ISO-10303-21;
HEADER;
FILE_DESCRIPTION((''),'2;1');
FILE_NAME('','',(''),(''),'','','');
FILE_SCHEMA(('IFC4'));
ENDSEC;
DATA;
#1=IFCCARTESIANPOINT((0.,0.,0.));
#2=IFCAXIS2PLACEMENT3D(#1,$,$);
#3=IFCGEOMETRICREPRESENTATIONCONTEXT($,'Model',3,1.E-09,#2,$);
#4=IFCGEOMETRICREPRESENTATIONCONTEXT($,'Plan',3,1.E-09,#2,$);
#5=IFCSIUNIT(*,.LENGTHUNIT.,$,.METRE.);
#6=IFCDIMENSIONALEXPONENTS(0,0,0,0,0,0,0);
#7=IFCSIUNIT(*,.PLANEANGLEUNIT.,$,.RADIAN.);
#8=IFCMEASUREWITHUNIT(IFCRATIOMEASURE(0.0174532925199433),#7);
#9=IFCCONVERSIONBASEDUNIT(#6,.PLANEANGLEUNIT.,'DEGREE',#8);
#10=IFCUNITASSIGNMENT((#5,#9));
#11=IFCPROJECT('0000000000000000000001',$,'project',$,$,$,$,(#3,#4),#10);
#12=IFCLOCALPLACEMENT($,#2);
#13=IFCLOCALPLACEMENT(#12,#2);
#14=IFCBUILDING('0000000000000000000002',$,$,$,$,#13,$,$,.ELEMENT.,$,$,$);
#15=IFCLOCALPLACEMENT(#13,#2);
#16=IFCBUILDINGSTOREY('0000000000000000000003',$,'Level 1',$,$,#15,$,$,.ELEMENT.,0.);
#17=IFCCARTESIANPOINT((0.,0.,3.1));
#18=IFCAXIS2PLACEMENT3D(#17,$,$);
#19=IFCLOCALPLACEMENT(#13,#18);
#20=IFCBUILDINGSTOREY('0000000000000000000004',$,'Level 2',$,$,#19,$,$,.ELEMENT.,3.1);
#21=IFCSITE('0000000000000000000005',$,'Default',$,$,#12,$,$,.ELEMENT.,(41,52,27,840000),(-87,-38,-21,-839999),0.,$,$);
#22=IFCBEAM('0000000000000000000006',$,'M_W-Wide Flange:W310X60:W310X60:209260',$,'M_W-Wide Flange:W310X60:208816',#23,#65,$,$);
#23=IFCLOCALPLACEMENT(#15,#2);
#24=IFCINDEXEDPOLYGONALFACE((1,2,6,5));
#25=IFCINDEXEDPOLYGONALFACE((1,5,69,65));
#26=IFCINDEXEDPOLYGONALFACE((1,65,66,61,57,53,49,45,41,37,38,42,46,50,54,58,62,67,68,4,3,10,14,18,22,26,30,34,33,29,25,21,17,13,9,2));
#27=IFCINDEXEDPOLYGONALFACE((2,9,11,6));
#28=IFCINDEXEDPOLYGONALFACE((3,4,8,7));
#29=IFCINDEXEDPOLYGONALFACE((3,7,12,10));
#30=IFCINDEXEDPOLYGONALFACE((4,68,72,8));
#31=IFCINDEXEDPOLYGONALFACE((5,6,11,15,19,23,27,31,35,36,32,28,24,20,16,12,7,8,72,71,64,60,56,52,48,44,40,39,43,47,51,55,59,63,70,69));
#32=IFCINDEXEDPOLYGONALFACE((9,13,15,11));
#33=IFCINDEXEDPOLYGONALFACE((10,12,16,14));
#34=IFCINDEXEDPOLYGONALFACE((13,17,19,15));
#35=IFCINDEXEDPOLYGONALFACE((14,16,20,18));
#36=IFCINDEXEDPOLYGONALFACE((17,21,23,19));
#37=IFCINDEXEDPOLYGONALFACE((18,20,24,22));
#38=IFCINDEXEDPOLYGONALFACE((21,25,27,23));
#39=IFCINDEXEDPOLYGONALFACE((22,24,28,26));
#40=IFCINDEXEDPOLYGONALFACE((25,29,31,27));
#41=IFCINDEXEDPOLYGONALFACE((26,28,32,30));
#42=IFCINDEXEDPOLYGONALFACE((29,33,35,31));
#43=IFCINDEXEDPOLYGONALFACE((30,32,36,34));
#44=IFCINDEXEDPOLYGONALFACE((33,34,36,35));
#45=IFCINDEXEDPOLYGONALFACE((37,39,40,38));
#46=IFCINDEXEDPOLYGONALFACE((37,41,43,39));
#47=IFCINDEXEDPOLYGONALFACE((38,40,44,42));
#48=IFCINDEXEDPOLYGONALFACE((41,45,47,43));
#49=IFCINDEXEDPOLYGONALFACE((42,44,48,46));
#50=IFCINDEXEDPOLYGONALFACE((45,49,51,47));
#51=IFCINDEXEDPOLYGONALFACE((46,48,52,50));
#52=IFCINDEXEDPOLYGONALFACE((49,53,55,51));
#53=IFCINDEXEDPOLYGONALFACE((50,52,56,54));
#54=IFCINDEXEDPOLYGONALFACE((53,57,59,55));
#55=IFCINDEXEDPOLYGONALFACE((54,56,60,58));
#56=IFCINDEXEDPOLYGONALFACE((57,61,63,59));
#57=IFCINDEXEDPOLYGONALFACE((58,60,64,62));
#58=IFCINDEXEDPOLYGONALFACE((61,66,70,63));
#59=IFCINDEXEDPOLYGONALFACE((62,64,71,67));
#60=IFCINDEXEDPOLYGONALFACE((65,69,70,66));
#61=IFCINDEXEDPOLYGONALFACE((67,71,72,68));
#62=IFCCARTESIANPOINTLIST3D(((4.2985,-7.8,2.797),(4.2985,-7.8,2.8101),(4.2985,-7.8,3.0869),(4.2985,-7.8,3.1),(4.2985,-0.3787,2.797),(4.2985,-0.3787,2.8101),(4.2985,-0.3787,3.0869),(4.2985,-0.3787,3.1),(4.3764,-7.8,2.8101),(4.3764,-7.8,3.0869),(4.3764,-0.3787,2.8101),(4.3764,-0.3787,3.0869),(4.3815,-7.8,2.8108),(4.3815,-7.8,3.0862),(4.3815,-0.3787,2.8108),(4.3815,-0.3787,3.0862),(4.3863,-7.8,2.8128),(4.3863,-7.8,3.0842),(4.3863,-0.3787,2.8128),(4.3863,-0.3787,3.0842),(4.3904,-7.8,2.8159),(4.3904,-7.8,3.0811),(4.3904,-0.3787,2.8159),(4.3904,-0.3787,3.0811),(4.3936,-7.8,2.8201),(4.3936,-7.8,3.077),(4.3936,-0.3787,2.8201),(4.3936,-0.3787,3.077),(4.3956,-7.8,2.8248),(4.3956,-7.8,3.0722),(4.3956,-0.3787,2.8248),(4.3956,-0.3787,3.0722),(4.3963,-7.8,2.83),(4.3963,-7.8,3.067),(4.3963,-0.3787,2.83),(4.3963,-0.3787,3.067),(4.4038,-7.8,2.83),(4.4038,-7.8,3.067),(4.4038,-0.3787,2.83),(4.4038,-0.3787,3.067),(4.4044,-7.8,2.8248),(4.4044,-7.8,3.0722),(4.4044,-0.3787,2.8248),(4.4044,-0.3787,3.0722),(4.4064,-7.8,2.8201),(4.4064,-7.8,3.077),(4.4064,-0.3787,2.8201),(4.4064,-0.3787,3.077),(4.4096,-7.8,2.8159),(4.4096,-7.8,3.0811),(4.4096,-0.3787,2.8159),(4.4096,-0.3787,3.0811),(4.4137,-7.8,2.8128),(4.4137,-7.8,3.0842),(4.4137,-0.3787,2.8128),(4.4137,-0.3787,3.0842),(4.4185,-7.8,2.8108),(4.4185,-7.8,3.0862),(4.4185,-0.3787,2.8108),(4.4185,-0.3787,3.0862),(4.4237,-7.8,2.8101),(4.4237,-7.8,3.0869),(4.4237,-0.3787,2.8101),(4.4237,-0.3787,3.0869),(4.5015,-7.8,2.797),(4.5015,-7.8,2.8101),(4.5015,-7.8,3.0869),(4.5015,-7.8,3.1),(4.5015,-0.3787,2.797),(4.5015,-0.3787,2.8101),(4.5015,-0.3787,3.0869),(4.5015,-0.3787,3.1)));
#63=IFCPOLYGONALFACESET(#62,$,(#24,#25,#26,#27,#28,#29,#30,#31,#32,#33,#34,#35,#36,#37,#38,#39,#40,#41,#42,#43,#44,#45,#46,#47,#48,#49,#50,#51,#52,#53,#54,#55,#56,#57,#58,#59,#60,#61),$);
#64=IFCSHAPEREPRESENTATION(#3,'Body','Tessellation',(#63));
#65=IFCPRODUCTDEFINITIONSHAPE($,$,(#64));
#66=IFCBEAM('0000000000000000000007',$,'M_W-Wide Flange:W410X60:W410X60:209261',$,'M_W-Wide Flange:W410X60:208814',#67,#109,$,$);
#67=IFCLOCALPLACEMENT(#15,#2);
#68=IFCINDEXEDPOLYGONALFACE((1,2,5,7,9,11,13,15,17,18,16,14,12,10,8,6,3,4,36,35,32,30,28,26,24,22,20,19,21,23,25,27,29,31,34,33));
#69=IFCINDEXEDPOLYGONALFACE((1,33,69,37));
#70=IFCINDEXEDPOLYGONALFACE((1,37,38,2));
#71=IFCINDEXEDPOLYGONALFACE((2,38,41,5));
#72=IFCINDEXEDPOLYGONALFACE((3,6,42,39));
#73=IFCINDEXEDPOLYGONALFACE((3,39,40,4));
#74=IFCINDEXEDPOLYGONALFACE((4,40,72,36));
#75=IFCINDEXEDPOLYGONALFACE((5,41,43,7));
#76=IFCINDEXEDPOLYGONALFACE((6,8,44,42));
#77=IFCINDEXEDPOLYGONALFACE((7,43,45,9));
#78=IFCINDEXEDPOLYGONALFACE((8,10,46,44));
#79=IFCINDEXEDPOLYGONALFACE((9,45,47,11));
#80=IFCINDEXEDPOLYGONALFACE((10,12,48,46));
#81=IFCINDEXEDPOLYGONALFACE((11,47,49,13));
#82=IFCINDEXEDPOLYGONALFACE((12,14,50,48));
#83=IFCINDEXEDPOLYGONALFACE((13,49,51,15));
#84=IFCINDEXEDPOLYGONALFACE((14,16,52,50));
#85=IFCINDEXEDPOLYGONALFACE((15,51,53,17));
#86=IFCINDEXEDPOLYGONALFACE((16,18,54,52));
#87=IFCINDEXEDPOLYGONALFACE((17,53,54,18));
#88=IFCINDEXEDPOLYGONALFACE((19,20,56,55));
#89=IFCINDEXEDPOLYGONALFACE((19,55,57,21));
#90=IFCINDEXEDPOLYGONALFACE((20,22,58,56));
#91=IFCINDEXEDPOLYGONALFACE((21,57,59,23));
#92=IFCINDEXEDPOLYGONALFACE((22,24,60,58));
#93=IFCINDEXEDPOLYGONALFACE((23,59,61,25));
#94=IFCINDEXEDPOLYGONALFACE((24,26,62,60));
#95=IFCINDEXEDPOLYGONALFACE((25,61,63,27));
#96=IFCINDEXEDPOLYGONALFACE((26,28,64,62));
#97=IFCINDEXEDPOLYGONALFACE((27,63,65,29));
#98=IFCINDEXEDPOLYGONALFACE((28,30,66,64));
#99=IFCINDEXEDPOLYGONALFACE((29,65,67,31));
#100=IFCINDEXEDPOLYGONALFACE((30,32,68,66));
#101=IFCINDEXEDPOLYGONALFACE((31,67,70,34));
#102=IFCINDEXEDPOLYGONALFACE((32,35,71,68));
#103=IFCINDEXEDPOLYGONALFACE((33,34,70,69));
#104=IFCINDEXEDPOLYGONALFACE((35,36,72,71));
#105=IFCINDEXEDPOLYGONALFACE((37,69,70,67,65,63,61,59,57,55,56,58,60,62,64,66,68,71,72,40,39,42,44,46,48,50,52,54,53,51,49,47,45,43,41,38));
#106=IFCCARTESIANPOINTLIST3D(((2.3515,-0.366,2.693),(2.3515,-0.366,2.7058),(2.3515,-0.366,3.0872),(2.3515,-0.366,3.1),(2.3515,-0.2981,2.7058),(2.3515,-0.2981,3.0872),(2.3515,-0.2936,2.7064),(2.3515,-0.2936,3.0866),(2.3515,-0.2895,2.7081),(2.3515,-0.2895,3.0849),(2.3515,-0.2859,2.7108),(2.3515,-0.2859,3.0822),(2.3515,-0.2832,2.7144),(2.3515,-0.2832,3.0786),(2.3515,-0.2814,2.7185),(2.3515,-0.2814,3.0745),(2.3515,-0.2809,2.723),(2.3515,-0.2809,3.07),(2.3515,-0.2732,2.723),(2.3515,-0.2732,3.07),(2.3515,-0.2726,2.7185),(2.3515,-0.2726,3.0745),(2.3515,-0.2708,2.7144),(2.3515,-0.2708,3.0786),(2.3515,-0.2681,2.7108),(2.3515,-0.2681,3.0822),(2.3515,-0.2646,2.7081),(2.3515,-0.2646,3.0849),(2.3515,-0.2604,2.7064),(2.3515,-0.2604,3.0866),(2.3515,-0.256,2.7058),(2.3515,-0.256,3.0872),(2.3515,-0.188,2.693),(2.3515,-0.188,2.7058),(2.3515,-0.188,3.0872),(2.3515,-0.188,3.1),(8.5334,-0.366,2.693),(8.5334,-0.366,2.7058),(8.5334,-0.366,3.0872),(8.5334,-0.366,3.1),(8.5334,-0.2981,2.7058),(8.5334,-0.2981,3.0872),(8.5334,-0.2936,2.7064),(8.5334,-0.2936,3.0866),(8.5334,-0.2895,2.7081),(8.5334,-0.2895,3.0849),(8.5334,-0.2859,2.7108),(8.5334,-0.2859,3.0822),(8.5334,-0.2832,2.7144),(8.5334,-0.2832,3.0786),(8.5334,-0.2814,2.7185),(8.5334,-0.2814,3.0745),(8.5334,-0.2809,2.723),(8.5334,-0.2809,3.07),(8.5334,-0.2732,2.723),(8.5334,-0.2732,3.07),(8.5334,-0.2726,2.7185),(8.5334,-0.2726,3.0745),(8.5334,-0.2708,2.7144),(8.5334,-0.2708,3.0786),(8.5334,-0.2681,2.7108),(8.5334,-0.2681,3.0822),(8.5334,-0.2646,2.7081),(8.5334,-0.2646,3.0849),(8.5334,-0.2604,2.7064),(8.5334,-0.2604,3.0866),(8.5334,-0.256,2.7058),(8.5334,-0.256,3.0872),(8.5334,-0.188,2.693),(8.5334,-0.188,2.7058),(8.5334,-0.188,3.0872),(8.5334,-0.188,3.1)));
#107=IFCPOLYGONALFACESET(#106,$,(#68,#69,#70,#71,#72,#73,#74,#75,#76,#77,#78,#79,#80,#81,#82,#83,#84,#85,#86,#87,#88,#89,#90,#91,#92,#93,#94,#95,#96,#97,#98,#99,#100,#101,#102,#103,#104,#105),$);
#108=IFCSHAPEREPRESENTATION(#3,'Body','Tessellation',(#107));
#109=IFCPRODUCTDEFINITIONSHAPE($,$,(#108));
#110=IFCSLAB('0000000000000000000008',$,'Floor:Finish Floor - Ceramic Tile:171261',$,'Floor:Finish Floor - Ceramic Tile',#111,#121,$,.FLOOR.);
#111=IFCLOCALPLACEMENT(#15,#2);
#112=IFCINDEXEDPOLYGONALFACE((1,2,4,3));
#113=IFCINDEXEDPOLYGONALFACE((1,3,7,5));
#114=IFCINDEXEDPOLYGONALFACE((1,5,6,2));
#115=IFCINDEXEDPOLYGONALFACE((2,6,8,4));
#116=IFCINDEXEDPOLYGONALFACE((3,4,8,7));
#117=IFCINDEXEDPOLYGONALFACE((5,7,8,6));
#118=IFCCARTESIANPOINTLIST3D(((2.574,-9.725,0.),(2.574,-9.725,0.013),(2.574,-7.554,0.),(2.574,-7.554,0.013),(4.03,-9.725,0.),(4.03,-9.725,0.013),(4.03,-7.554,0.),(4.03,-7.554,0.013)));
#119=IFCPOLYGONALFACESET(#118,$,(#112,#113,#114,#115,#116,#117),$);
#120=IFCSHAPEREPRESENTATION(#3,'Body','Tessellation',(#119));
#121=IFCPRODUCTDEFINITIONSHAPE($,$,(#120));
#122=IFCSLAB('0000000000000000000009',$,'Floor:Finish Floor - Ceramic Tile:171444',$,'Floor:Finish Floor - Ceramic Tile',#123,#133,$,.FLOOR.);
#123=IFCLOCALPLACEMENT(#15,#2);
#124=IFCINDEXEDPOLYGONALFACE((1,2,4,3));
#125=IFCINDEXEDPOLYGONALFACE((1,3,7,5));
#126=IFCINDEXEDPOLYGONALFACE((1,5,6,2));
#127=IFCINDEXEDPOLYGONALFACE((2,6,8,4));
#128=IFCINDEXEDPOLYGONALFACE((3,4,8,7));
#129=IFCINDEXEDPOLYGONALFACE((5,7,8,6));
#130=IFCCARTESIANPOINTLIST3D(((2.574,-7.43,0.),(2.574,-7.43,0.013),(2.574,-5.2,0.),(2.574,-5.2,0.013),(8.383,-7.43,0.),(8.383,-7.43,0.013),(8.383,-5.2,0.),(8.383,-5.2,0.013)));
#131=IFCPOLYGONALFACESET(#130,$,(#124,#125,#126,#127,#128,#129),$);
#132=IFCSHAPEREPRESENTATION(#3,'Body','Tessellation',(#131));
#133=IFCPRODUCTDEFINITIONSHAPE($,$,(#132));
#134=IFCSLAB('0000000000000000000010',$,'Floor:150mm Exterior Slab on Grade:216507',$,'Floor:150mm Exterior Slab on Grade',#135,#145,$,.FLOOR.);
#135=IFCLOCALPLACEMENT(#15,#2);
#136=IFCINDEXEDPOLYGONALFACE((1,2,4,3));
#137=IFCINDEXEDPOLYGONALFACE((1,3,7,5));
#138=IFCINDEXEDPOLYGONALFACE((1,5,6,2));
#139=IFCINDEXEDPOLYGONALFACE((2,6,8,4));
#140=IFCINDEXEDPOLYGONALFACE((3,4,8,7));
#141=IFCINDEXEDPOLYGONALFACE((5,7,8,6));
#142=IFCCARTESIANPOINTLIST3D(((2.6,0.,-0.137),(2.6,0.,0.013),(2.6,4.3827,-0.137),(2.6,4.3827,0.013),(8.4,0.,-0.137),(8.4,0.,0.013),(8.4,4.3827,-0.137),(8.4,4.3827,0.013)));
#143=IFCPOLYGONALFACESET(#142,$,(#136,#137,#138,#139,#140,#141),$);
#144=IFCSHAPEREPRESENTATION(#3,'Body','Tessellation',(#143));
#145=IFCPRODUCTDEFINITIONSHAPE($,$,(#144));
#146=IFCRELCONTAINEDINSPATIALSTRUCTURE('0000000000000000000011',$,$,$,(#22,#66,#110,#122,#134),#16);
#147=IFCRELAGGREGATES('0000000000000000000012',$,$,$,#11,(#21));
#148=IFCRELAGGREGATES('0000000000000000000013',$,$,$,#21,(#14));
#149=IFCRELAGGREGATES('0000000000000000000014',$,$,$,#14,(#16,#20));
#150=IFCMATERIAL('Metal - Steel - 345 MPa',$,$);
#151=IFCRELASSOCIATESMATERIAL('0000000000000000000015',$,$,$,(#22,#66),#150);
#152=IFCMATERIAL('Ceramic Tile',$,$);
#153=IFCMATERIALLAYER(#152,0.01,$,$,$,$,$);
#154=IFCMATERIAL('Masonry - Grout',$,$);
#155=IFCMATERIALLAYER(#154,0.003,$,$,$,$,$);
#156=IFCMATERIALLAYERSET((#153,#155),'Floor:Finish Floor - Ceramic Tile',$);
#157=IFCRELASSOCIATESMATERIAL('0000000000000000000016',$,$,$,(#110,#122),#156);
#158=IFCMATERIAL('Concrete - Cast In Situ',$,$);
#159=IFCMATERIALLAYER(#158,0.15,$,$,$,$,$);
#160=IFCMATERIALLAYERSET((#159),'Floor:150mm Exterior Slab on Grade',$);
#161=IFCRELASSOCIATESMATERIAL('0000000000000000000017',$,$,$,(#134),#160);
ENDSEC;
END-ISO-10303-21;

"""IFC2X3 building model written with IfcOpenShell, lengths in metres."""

from ifc_helpers import new_model, entity, si_unit, converted_unit, frame, frame_2d, origin, place, context, project, spatial, polyline, circle_curve, parameter, trimmed, segment, composite_curve, rectangle, outline, extrude, material, layer, layer_set, layer_usage, element, save


model = new_model("IFC2X3")

# Units and contexts
model_context = context("Model", 3, precision=1e-09, world=origin())
plan_context = context("Plan", 3, precision=1e-09, world=origin())
ifc_project = project(units=[si_unit("LENGTHUNIT", "METRE"), converted_unit("PLANEANGLEUNIT", "DEGREE", entity("IfcRatioMeasure", 0.0174532925199433), si_unit("PLANEANGLEUNIT", "RADIAN"), dimensions=[0, 0, 0, 0, 0, 0, 0])], contexts=[model_context, plan_context])

# Site, building, storey
site_placement = place(None, origin())
site = spatial("IfcSite", under=ifc_project, at=site_placement, Name="Default", CompositionType="ELEMENT", RefLatitude=(41, 52, 27, 840000), RefLongitude=(-87, -38, -21, -839999), RefElevation=0.0)
building_placement = place(site_placement, origin())
building = spatial("IfcBuilding", under=site, at=building_placement, CompositionType="ELEMENT")
storey_1_placement = place(building_placement, origin())
storey_1 = spatial("IfcBuildingStorey", under=building, at=storey_1_placement, Name="Level 1", CompositionType="ELEMENT", Elevation=0.0)

# Beams
ifc_material_1 = material(Name="Metal - Steel - 345 MPa")
beam_1_placement = place(storey_1_placement, frame((4.4, -7.8, 3.1)))
element("IfcBeam", 1, at=beam_1_placement, inside=storey_1, material=ifc_material_1, Name="M_W-Wide Flange:W310X60:W310X60:209260", ObjectType="M_W-Wide Flange:W310X60:208816", context=model_context, shape_type="SweptSolid", body=[
    extrude(outline(composite_curve([segment(polyline([(-0.1015, -0.1384), (-0.1015, -0.1515)]), True, "CONTINUOUS"), segment(polyline([(-0.1015, -0.1515), (0.1015, -0.1515)]), True, "CONTINUOUS"), segment(polyline([(0.1015, -0.1515), (0.1015, -0.1384)]), True, "CONTINUOUS"), segment(polyline([(0.1015, -0.1384), (0.0236, -0.1384)]), True, "CONTINUOUS"), segment(trimmed(circle_curve(frame_2d((0.0236, -0.1185), x_axis=(1.0, 0.0)), 0.0199), [parameter(180.0)], [parameter(270.0)], True, "PARAMETER"), False, "CONTINUOUS"), segment(polyline([(0.0037, -0.1185), (0.0037, 0.1185)]), True, "CONTINUOUS"), segment(trimmed(circle_curve(frame_2d((0.0236, 0.1185), x_axis=(1.0, 0.0)), 0.0199), [parameter(90.0)], [parameter(180.0)], True, "PARAMETER"), False, "CONTINUOUS"), segment(polyline([(0.0236, 0.1384), (0.1015, 0.1384)]), True, "CONTINUOUS"), segment(polyline([(0.1015, 0.1384), (0.1015, 0.1515)]), True, "CONTINUOUS"), segment(polyline([(0.1015, 0.1515), (-0.1015, 0.1515)]), True, "CONTINUOUS"), segment(polyline([(-0.1015, 0.1515), (-0.1015, 0.1384)]), True, "CONTINUOUS"), segment(polyline([(-0.1015, 0.1384), (-0.0237, 0.1384)]), True, "CONTINUOUS"), segment(trimmed(circle_curve(frame_2d((-0.0237, 0.1185), x_axis=(1.0, 0.0)), 0.0199), [parameter(360.0)], [parameter(90.0)], True, "PARAMETER"), False, "CONTINUOUS"), segment(polyline([(-0.0038, 0.1185), (-0.0038, -0.1185)]), True, "CONTINUOUS"), segment(trimmed(circle_curve(frame_2d((-0.0237, -0.1185), x_axis=(1.0, 0.0)), 0.0199), [parameter(270.0)], [parameter(0.0)], True, "PARAMETER"), False, "CONTINUOUS"), segment(polyline([(-0.0237, -0.1384), (-0.1015, -0.1384)]), True, "CONTINUOUS")], self_intersect=False)), frame((0.0, 0.0, -0.1515), z_axis=(0.0, -1.0, 0.0), x_axis=(1.0, 0.0, 0.0)), (0.0, 0.0, -1.0), 7.4213),
])
beam_2_placement = place(storey_1_placement, frame((8.5915, -0.277, 3.1), z_axis=(0.0, 0.0, 1.0), x_axis=(0.0, 1.0, 0.0)))
element("IfcBeam", 2, at=beam_2_placement, inside=storey_1, material=ifc_material_1, Name="M_W-Wide Flange:W410X60:W410X60:209261", ObjectType="M_W-Wide Flange:W410X60:208814", context=model_context, shape_type="SweptSolid", body=[
    extrude(outline(composite_curve([segment(polyline([(0.1907, -0.089), (0.2035, -0.089)]), True, "CONTINUOUS"), segment(polyline([(0.2035, -0.089), (0.2035, 0.089)]), True, "CONTINUOUS"), segment(polyline([(0.2035, 0.089), (0.1907, 0.089)]), True, "CONTINUOUS"), segment(polyline([(0.1907, 0.089), (0.1907, 0.021)]), True, "CONTINUOUS"), segment(trimmed(circle_curve(frame_2d((0.1735, 0.021), x_axis=(1.0, 0.0)), 0.0172), [parameter(270.0)], [parameter(360.0)], True, "PARAMETER"), False, "CONTINUOUS"), segment(polyline([(0.1735, 0.0038), (-0.1735, 0.0038)]), True, "CONTINUOUS"), segment(trimmed(circle_curve(frame_2d((-0.1735, 0.021), x_axis=(0.0, -1.0)), 0.0172), [parameter(270.0)], [parameter(360.0)], True, "PARAMETER"), False, "CONTINUOUS"), segment(polyline([(-0.1907, 0.021), (-0.1907, 0.089)]), True, "CONTINUOUS"), segment(polyline([(-0.1907, 0.089), (-0.2035, 0.089)]), True, "CONTINUOUS"), segment(polyline([(-0.2035, 0.089), (-0.2035, -0.089)]), True, "CONTINUOUS"), segment(polyline([(-0.2035, -0.089), (-0.1907, -0.089)]), True, "CONTINUOUS"), segment(polyline([(-0.1907, -0.089), (-0.1907, -0.0211)]), True, "CONTINUOUS"), segment(trimmed(circle_curve(frame_2d((-0.1735, -0.0211), x_axis=(-1.0, 0.0)), 0.0172), [parameter(270.0)], [parameter(0.0)], True, "PARAMETER"), False, "CONTINUOUS"), segment(polyline([(-0.1735, -0.0039), (0.1735, -0.0039)]), True, "CONTINUOUS"), segment(trimmed(circle_curve(frame_2d((0.1735, -0.0211), x_axis=(0.0, 1.0)), 0.0172), [parameter(270.0)], [parameter(0.0)], True, "PARAMETER"), False, "CONTINUOUS"), segment(polyline([(0.1907, -0.0211), (0.1907, -0.089)]), True, "CONTINUOUS")], self_intersect=False)), frame((0.0, 6.24, -0.2035), z_axis=(0.0, -1.0, 0.0), x_axis=(0.0, 0.0, -1.0)), (0.0, 0.0, 1.0), 6.1819),
])

# Slabs
ifc_material_2 = material(Name="Ceramic Tile")
ifc_layer_1 = layer(ifc_material_2, 0.01)
ifc_material_3 = material(Name="Masonry - Grout")
ifc_layer_2 = layer(ifc_material_3, 0.003)
ifc_layer_set_1 = layer_set([ifc_layer_1, ifc_layer_2], Name="Floor:Finish Floor - Ceramic Tile")
ifc_layer_usage_1 = layer_usage(ifc_layer_set_1, "AXIS3", "POSITIVE", 0.0)
slab_1_placement = place(storey_1_placement, frame((2.574, -9.725, 0.0)))
element("IfcSlab", 3, at=slab_1_placement, inside=storey_1, material=ifc_layer_usage_1, Name="Floor:Finish Floor - Ceramic Tile:171261", ObjectType="Floor:Finish Floor - Ceramic Tile", PredefinedType="FLOOR", context=model_context, shape_type="SweptSolid", body=[
    extrude(rectangle(XDim=2.171, YDim=1.456, at=frame_2d((0.0, 0.0), x_axis=(0.0, -1.0))), frame((0.728, 1.0855, 0.013), z_axis=(0.0, 0.0, -1.0), x_axis=(-1.0, 0.0, 0.0)), (0.0, 0.0, 1.0), 0.013),
])
slab_2_placement = place(storey_1_placement, frame((2.574, -7.43, 0.0)))
element("IfcSlab", 4, at=slab_2_placement, inside=storey_1, material=ifc_layer_usage_1, Name="Floor:Finish Floor - Ceramic Tile:171444", ObjectType="Floor:Finish Floor - Ceramic Tile", PredefinedType="FLOOR", context=model_context, shape_type="SweptSolid", body=[
    extrude(rectangle(XDim=5.809, YDim=2.23, at=frame_2d((0.0, 0.0), x_axis=(-1.0, 0.0))), frame((2.9045, 1.115, 0.013), z_axis=(0.0, 0.0, -1.0), x_axis=(-1.0, 0.0, 0.0)), (0.0, 0.0, 1.0), 0.013),
])
ifc_material_4 = material(Name="Concrete - Cast In Situ")
ifc_layer_3 = layer(ifc_material_4, 0.15)
ifc_layer_set_2 = layer_set([ifc_layer_3], Name="Floor:150mm Exterior Slab on Grade")
ifc_layer_usage_2 = layer_usage(ifc_layer_set_2, "AXIS3", "POSITIVE", 0.0)
slab_3_placement = place(storey_1_placement, frame((2.6, 0.0, -0.137)))
element("IfcSlab", 5, at=slab_3_placement, inside=storey_1, material=ifc_layer_usage_2, Name="Floor:150mm Exterior Slab on Grade:216507", ObjectType="Floor:150mm Exterior Slab on Grade", PredefinedType="FLOOR", context=model_context, shape_type="SweptSolid", body=[
    extrude(rectangle(XDim=5.8, YDim=4.3827, at=frame_2d((0.0, 0.0), x_axis=(-1.0, 0.0))), frame((2.9, 2.1914, 0.15), z_axis=(0.0, 0.0, -1.0), x_axis=(-1.0, 0.0, 0.0)), (0.0, 0.0, 1.0), 0.15),
])

# Shared definitions
storey_2_placement = place(building_placement, frame((0.0, 0.0, 3.1)))
storey_2 = spatial("IfcBuildingStorey", under=building, at=storey_2_placement, Name="Level 2", CompositionType="ELEMENT", Elevation=3.1)

save(model, "model.ifc")
